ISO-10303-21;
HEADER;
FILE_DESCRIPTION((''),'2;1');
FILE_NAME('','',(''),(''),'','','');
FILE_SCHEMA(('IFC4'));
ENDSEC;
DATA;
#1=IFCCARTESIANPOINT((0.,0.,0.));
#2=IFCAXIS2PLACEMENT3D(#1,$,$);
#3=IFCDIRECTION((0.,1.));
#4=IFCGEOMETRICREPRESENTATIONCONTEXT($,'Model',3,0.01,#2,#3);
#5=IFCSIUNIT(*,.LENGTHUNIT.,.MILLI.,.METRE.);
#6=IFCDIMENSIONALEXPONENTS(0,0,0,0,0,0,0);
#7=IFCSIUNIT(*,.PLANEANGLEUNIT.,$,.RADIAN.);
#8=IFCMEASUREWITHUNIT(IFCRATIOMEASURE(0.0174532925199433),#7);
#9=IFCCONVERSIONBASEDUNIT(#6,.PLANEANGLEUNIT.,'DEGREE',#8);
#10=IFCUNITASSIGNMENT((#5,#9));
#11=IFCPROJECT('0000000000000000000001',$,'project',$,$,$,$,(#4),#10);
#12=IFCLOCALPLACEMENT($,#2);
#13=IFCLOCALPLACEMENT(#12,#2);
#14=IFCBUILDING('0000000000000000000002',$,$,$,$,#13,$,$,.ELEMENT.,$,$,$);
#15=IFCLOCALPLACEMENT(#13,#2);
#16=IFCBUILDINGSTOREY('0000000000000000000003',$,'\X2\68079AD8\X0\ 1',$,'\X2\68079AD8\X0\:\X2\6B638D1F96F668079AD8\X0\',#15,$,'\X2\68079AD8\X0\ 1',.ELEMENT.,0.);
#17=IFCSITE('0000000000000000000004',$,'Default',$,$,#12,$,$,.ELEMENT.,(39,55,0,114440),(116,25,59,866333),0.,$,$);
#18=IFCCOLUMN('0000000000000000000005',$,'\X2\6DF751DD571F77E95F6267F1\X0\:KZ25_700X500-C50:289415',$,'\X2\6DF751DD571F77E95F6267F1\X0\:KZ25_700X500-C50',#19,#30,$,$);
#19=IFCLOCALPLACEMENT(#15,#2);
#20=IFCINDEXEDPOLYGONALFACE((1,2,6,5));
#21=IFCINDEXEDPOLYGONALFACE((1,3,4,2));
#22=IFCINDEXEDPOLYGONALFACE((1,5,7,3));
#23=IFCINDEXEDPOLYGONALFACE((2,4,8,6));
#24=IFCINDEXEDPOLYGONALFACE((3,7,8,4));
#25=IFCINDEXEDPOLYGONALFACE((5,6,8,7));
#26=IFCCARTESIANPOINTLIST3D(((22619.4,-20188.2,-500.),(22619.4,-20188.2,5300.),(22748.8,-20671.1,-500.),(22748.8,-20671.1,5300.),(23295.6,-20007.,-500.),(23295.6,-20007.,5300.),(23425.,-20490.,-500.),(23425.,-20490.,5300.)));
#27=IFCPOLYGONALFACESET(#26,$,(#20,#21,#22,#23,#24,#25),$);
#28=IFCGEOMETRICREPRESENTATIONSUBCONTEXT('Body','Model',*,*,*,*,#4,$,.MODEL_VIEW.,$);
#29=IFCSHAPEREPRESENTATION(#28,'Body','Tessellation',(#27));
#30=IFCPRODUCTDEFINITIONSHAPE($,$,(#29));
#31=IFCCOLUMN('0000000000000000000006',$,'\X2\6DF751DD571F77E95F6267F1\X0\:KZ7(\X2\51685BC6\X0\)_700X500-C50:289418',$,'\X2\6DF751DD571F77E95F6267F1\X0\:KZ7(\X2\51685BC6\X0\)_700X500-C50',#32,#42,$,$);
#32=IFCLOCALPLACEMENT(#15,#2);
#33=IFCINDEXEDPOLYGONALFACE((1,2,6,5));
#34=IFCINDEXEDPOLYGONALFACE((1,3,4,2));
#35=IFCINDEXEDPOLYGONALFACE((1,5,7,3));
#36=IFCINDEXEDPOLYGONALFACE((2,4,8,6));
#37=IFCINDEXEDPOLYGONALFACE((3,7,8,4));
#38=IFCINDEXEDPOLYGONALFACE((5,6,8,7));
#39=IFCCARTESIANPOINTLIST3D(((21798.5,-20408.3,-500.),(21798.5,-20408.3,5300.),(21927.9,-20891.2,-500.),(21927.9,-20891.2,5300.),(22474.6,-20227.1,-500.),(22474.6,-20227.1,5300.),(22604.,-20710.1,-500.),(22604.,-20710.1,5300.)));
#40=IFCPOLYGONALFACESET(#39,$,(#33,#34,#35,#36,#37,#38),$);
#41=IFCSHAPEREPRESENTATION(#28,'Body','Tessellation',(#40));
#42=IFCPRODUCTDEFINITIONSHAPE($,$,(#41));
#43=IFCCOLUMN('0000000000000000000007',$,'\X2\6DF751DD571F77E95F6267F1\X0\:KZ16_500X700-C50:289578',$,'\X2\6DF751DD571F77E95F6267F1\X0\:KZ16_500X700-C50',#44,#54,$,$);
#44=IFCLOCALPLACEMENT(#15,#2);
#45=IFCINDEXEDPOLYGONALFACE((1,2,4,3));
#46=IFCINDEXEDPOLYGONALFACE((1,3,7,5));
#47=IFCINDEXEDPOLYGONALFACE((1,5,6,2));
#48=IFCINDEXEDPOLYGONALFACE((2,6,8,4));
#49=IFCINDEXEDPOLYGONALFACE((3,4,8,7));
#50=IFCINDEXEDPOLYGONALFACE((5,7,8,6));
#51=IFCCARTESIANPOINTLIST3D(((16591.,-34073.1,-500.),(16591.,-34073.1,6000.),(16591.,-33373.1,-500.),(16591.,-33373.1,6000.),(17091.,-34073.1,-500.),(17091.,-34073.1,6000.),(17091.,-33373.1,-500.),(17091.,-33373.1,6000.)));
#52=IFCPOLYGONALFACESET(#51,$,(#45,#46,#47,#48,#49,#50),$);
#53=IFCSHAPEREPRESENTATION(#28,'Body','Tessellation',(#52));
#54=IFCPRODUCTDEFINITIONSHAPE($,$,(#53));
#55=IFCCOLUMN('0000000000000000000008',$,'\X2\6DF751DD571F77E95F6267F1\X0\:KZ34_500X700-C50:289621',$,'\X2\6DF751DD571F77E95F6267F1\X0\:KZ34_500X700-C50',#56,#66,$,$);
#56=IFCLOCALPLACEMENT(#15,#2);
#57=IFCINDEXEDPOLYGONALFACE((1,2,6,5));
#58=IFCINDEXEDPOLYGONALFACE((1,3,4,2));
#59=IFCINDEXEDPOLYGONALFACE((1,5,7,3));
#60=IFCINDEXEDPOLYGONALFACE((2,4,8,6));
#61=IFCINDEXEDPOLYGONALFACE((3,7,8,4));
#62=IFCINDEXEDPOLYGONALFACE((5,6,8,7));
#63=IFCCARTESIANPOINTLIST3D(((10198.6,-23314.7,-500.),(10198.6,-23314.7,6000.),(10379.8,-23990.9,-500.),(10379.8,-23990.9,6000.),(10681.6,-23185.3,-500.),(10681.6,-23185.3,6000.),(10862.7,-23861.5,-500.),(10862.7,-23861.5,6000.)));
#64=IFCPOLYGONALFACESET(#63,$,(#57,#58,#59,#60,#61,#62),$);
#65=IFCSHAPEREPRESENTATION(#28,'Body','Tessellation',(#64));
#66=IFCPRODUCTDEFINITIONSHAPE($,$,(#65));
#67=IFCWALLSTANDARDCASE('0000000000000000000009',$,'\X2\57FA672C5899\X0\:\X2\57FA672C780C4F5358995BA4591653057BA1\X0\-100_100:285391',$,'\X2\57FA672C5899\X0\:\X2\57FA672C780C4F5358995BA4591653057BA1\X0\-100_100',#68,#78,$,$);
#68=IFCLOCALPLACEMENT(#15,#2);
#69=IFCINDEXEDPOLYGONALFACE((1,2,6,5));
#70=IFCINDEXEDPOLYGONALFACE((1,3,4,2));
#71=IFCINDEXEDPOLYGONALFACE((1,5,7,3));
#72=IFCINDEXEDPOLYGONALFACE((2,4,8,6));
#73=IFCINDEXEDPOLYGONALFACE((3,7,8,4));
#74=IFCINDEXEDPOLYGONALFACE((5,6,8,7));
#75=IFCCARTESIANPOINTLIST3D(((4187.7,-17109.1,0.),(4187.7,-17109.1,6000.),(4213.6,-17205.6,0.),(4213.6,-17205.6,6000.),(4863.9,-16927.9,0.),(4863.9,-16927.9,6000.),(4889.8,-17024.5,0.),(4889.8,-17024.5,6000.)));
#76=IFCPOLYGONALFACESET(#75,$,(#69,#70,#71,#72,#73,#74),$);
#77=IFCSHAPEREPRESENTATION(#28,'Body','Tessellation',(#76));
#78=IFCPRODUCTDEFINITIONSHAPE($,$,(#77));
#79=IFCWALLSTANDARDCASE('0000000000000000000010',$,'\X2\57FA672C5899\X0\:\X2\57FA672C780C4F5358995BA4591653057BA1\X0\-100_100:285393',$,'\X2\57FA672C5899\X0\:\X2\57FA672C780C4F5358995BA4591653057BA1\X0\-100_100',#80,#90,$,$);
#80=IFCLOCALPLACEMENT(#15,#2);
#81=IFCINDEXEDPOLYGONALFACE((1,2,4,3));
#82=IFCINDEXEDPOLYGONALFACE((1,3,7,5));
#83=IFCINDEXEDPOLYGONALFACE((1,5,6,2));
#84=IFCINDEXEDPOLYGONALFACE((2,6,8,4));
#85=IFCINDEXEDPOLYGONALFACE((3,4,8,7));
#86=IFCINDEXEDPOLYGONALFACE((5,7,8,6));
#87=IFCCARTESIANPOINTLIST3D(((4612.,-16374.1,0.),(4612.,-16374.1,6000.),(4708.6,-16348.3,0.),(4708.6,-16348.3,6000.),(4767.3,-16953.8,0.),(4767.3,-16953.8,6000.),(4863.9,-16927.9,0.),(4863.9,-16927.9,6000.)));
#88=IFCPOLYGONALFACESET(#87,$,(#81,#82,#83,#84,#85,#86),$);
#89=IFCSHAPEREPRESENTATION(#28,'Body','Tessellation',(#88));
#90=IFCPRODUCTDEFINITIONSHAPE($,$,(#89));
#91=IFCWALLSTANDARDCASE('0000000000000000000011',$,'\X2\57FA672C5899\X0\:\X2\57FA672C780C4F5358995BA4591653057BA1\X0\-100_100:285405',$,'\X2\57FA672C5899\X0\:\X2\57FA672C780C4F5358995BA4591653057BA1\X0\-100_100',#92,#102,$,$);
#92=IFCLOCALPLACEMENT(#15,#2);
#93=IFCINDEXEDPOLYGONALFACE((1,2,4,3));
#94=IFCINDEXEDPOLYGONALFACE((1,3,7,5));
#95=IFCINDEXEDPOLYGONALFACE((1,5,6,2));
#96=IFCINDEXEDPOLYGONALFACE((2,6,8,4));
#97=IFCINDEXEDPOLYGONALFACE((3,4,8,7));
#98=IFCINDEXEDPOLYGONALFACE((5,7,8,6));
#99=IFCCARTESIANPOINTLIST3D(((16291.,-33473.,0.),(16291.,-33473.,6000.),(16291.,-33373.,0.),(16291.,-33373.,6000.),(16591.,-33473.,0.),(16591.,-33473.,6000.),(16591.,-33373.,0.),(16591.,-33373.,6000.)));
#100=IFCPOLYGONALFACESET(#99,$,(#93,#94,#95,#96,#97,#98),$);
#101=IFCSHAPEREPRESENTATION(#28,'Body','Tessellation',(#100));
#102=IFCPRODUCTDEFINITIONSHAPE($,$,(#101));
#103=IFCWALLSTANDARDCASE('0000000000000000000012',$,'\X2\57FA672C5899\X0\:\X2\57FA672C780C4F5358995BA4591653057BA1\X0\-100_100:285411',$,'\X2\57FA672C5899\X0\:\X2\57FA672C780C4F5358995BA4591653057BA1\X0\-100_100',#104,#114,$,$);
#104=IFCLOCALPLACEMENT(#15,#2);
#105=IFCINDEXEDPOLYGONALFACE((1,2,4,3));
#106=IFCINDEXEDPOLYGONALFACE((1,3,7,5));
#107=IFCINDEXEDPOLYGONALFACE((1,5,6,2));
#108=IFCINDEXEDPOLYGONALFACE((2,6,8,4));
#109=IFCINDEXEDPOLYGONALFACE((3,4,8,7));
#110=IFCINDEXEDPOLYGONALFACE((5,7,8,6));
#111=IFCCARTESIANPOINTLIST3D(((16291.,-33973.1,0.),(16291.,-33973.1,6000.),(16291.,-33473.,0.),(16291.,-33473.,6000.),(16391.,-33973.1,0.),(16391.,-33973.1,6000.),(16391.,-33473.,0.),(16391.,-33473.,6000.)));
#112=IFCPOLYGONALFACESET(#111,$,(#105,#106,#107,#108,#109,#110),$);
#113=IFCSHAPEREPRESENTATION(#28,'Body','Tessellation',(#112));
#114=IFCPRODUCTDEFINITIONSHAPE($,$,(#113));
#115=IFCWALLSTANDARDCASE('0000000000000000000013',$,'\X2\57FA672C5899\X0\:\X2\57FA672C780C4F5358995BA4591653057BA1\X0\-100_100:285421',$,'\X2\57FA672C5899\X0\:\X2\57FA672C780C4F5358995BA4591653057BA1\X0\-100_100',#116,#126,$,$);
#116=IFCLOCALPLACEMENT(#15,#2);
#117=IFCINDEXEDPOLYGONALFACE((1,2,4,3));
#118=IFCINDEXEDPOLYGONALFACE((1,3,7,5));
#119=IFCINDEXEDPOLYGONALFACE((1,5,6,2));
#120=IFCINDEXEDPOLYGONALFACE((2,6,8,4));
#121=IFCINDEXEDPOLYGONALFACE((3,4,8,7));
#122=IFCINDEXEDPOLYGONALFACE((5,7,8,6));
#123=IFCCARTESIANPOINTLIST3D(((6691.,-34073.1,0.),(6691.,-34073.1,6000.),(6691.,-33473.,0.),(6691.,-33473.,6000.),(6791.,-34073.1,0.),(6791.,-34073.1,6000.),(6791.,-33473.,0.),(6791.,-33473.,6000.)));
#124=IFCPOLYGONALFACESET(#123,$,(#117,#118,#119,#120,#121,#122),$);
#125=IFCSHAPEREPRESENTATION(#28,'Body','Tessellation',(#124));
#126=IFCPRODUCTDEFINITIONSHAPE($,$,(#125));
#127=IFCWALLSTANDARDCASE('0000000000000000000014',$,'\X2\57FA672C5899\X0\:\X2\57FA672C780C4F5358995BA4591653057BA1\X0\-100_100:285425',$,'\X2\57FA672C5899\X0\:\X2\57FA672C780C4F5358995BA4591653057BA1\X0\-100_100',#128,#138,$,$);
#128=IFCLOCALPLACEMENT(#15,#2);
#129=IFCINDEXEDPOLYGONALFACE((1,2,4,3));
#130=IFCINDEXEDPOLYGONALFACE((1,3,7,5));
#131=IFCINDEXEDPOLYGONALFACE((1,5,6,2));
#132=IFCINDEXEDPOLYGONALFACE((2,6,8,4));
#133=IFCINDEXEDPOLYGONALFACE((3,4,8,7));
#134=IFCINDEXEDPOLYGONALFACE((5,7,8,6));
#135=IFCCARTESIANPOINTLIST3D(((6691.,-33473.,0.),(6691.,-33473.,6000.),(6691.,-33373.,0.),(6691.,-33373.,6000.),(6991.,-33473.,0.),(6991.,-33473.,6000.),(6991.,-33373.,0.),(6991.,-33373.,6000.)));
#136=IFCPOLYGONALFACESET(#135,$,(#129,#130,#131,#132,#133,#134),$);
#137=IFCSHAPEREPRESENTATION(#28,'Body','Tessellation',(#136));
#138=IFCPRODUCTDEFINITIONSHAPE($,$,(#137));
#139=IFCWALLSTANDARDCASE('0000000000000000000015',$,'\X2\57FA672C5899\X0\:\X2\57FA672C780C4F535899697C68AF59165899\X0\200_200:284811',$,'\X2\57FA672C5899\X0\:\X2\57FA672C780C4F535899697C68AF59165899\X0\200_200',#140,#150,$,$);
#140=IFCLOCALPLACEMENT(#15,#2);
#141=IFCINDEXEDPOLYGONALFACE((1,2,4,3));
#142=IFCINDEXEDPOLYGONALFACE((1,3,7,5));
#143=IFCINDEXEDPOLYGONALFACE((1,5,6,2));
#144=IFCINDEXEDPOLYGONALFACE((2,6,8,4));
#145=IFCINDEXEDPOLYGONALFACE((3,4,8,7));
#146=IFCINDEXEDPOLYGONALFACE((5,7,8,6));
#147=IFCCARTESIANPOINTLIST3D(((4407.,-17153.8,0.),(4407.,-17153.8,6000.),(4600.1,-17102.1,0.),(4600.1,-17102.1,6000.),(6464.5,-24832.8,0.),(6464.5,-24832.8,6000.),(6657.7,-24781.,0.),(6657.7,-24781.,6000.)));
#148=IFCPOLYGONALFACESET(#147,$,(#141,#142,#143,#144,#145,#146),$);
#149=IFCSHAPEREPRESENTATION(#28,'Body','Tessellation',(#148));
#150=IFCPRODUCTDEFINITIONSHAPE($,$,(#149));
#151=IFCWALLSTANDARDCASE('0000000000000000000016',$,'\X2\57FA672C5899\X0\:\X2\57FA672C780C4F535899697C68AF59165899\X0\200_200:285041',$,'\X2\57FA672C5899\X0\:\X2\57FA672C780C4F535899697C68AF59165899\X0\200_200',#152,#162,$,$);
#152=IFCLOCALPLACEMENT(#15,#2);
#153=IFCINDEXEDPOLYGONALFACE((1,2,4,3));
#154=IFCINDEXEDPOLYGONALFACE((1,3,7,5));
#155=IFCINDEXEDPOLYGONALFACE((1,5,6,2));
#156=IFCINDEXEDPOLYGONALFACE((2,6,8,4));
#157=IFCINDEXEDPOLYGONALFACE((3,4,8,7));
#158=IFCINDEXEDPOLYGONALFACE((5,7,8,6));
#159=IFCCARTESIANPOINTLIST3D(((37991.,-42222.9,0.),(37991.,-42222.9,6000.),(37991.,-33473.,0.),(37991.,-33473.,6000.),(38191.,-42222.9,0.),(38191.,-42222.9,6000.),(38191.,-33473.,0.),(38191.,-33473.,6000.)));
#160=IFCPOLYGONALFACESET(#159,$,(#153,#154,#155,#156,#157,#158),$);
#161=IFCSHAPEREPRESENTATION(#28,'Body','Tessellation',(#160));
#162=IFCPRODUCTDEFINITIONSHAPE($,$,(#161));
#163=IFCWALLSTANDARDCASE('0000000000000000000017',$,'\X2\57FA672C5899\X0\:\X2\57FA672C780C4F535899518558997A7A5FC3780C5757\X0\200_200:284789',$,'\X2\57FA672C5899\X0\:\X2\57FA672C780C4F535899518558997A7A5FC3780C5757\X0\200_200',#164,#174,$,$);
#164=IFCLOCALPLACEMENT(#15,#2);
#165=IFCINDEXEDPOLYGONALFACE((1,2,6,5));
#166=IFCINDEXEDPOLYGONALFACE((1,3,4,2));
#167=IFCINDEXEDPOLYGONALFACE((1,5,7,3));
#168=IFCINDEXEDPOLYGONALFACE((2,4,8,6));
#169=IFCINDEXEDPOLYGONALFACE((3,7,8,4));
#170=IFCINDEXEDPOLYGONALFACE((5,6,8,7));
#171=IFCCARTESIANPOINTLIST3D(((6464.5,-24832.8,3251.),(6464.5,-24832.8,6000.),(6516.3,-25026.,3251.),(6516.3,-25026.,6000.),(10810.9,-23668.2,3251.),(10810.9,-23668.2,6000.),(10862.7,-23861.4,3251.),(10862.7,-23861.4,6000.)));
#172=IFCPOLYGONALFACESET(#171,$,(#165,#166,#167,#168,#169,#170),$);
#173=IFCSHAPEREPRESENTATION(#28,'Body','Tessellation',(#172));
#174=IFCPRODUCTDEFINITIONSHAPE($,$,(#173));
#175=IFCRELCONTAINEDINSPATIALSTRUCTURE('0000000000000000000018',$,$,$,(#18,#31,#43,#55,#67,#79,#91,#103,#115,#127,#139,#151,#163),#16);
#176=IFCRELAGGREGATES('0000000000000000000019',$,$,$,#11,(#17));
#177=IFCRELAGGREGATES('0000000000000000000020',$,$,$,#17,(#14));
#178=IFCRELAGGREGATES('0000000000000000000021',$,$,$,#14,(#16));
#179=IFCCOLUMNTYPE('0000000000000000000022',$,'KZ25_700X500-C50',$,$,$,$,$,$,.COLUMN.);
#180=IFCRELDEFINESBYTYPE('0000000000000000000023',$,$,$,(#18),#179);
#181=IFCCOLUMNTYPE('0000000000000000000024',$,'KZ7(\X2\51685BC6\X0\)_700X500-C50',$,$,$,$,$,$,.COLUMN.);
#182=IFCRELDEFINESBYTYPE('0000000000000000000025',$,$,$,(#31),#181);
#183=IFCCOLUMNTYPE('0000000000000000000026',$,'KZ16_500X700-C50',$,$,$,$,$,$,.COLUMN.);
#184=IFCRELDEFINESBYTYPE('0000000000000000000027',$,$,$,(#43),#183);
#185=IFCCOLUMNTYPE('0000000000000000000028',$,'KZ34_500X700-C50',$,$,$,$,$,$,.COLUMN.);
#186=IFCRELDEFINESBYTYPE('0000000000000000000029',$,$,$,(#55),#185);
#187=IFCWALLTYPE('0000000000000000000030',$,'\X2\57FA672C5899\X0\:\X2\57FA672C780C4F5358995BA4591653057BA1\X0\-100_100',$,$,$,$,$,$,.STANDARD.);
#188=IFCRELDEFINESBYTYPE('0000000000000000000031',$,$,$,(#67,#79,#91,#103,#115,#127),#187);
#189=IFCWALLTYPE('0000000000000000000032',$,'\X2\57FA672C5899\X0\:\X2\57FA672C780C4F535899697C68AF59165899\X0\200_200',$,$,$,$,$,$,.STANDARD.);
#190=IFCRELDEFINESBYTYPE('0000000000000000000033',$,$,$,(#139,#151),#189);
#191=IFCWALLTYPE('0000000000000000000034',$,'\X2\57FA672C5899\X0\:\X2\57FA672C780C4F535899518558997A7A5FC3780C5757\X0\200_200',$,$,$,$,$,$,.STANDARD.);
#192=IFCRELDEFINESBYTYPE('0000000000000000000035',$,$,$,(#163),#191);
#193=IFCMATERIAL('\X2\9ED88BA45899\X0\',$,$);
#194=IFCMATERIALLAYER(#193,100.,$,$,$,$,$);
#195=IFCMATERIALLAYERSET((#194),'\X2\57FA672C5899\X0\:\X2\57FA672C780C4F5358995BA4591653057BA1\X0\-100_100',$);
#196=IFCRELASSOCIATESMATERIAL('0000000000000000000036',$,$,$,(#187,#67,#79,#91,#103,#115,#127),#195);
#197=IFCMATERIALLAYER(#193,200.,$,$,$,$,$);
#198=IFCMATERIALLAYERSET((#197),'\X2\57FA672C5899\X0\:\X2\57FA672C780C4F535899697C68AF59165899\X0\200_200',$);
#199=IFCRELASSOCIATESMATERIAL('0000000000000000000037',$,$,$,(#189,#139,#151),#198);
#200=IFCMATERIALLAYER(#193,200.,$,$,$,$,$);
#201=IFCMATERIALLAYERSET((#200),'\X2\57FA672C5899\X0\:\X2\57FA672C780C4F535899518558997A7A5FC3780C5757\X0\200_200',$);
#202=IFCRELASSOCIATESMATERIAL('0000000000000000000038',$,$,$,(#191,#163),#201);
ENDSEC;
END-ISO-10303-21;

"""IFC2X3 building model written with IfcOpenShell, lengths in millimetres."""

from ifc_helpers import new_model, entity, si_unit, converted_unit, direction, frame, frame_2d, origin, origin_2d_with_axis, place, context, subcontext, project, spatial, rectangle, extrude, source, transform, mapped, material, layer, layer_set, layer_usage, type_object, type_shapes, element, save


model = new_model("IFC2X3")

# Units and contexts
model_context = context("Model", 3, precision=0.01, world=origin(), true_north=direction((0.0, 1.0)))
body_context = subcontext(model_context, "Body", "Model", "MODEL_VIEW")
ifc_project = project(units=[si_unit("LENGTHUNIT", "METRE", prefix="MILLI"), converted_unit("PLANEANGLEUNIT", "DEGREE", entity("IfcRatioMeasure", 0.0174532925199433), si_unit("PLANEANGLEUNIT", "RADIAN"), dimensions=[0, 0, 0, 0, 0, 0, 0])], contexts=[model_context])

# Site, building, storey
site_placement = place(None, origin())
site = spatial("IfcSite", under=ifc_project, at=site_placement, Name="Default", CompositionType="ELEMENT", RefLatitude=(39, 55, 0, 114440), RefLongitude=(116, 25, 59, 866333), RefElevation=0.0)
building_placement = place(site_placement, origin())
building = spatial("IfcBuilding", under=site, at=building_placement, CompositionType="ELEMENT")
storey_placement = place(building_placement, origin())
storey = spatial("IfcBuildingStorey", under=building, at=storey_placement, Name="标高 1", ObjectType="标高:正负零标高", LongName="标高 1", CompositionType="ELEMENT", Elevation=0.0)

# Columns
column_type_1 = type_object("IfcColumnType", Name="KZ25_700X500-C50", PredefinedType="COLUMN")
shared_shape_1 = source(origin(), body_context, "Body", "SweptSolid", [
    extrude(rectangle(XDim=500.0, YDim=700.0, at=origin_2d_with_axis()), frame((0.0, 0.0, -500.0), z_axis=(0.0, 0.0, 1.0), x_axis=(0.0, -1.0, 0.0)), (0.0, 0.0, 1.0), 5800.0),
])
type_shapes(column_type_1, [shared_shape_1])
column_1_placement = place(building_placement, frame((23022.2, -20339.1, 0.0), z_axis=(0.0, 0.0, 1.0), x_axis=(0.965926, 0.258819, 0.0)))
element("IfcColumn", 1, at=column_1_placement, inside=storey, type_object=column_type_1, Name="混凝土矩形柱:KZ25_700X500-C50:289415", ObjectType="混凝土矩形柱:KZ25_700X500-C50", context=body_context, shape_type="MappedRepresentation", body=[
    mapped(shared_shape_1, transform((0.0, 0.0, 0.0), scale=1.0)),
])
column_type_2 = type_object("IfcColumnType", Name="KZ7(全密)_700X500-C50", PredefinedType="COLUMN")
shared_shape_2 = source(origin(), body_context, "Body", "SweptSolid", [
    extrude(rectangle(XDim=500.0, YDim=700.0, at=origin_2d_with_axis()), frame((0.0, 0.0, -500.0), z_axis=(0.0, 0.0, 1.0), x_axis=(0.0, -1.0, 0.0)), (0.0, 0.0, 1.0), 5800.0),
])
type_shapes(column_type_2, [shared_shape_2])
column_2_placement = place(building_placement, frame((22201.2, -20559.2, 0.0), z_axis=(0.0, 0.0, 1.0), x_axis=(0.965926, 0.258819, 0.0)))
element("IfcColumn", 2, at=column_2_placement, inside=storey, type_object=column_type_2, Name="混凝土矩形柱:KZ7(全密)_700X500-C50:289418", ObjectType="混凝土矩形柱:KZ7(全密)_700X500-C50", context=body_context, shape_type="MappedRepresentation", body=[
    mapped(shared_shape_2, transform((0.0, 0.0, 0.0), scale=1.0)),
])
column_type_3 = type_object("IfcColumnType", Name="KZ16_500X700-C50", PredefinedType="COLUMN")
shared_shape_3 = source(origin(), body_context, "Body", "SweptSolid", [
    extrude(rectangle(XDim=700.0, YDim=500.0, at=origin_2d_with_axis()), frame((0.0, 0.0, -500.0), z_axis=(0.0, 0.0, 1.0), x_axis=(0.0, -1.0, 0.0)), (0.0, 0.0, 1.0), 6500.0),
])
type_shapes(column_type_3, [shared_shape_3])
column_3_placement = place(building_placement, frame((16841.0, -33723.1, 0.0)))
element("IfcColumn", 3, at=column_3_placement, inside=storey, type_object=column_type_3, Name="混凝土矩形柱:KZ16_500X700-C50:289578", ObjectType="混凝土矩形柱:KZ16_500X700-C50", context=body_context, shape_type="MappedRepresentation", body=[
    mapped(shared_shape_3, transform((0.0, 0.0, 0.0), scale=1.0)),
])
column_type_4 = type_object("IfcColumnType", Name="KZ34_500X700-C50", PredefinedType="COLUMN")
shared_shape_4 = source(origin(), body_context, "Body", "SweptSolid", [
    extrude(rectangle(XDim=700.0, YDim=500.0, at=origin_2d_with_axis()), frame((0.0, 0.0, -500.0), z_axis=(0.0, 0.0, 1.0), x_axis=(0.0, -1.0, 0.0)), (0.0, 0.0, 1.0), 6500.0),
])
type_shapes(column_type_4, [shared_shape_4])
column_4_placement = place(building_placement, frame((10530.7, -23588.1, 0.0), z_axis=(0.0, 0.0, 1.0), x_axis=(0.965926, 0.258819, 0.0)))
element("IfcColumn", 4, at=column_4_placement, inside=storey, type_object=column_type_4, Name="混凝土矩形柱:KZ34_500X700-C50:289621", ObjectType="混凝土矩形柱:KZ34_500X700-C50", context=body_context, shape_type="MappedRepresentation", body=[
    mapped(shared_shape_4, transform((0.0, 0.0, 0.0), scale=1.0)),
])

# Walls
ifc_material = material(Name="默认墙")
ifc_layer_1 = layer(ifc_material, 100.0)
ifc_layer_set_1 = layer_set([ifc_layer_1], Name="基本墙:基本砌体墙室外包管-100_100")
ifc_layer_usage_1 = layer_usage(ifc_layer_set_1, "AXIS2", "NEGATIVE", 50.0)
wall_type_1 = type_object("IfcWallType", Name="基本墙:基本砌体墙室外包管-100_100", PredefinedType="STANDARD", material=ifc_layer_set_1)
wall_1_placement = place(building_placement, frame((4200.7, -17157.3, 0.0), z_axis=(0.0, 0.0, 1.0), x_axis=(0.965926, 0.258819, 0.0)))
element("IfcWallStandardCase", 5, at=wall_1_placement, inside=storey, type_object=wall_type_1, material=ifc_layer_usage_1, Name="基本墙:基本砌体墙室外包管-100_100:285391", ObjectType="基本墙:基本砌体墙室外包管-100_100", context=body_context, shape_type="SweptSolid", body=[
    extrude(rectangle(XDim=700.0, YDim=100.0, at=frame_2d((350.0, 0.0), x_axis=(-1.0, 0.0))), origin(), (0.0, 0.0, 1.0), 6000.0),
])
ifc_layer_usage_2 = layer_usage(ifc_layer_set_1, "AXIS2", "NEGATIVE", 50.0)
wall_2_placement = place(building_placement, frame((4815.6, -16940.8, 0.0), z_axis=(0.0, 0.0, 1.0), x_axis=(-0.258819, 0.965926, 0.0)))
element("IfcWallStandardCase", 6, at=wall_2_placement, inside=storey, type_object=wall_type_1, material=ifc_layer_usage_2, Name="基本墙:基本砌体墙室外包管-100_100:285393", ObjectType="基本墙:基本砌体墙室外包管-100_100", context=body_context, shape_type="SweptSolid", body=[
    extrude(rectangle(XDim=600.1, YDim=100.0, at=frame_2d((300.0, 0.0), x_axis=(-1.0, 0.0))), origin(), (0.0, 0.0, 1.0), 6000.0),
])
ifc_layer_usage_3 = layer_usage(ifc_layer_set_1, "AXIS2", "NEGATIVE", 50.0)
wall_3_placement = place(building_placement, frame((16291.0, -33423.0, 0.0)))
element("IfcWallStandardCase", 7, at=wall_3_placement, inside=storey, type_object=wall_type_1, material=ifc_layer_usage_3, Name="基本墙:基本砌体墙室外包管-100_100:285405", ObjectType="基本墙:基本砌体墙室外包管-100_100", context=body_context, shape_type="SweptSolid", body=[
    extrude(rectangle(XDim=300.0, YDim=100.0, at=frame_2d((150.0, 0.0), x_axis=(-1.0, 0.0))), origin(), (0.0, 0.0, 1.0), 6000.0),
])
ifc_layer_usage_4 = layer_usage(ifc_layer_set_1, "AXIS2", "NEGATIVE", 50.0)
wall_4_placement = place(building_placement, frame((16341.0, -33473.0, 0.0), z_axis=(0.0, 0.0, 1.0), x_axis=(0.0, -1.0, 0.0)))
element("IfcWallStandardCase", 8, at=wall_4_placement, inside=storey, type_object=wall_type_1, material=ifc_layer_usage_4, Name="基本墙:基本砌体墙室外包管-100_100:285411", ObjectType="基本墙:基本砌体墙室外包管-100_100", context=body_context, shape_type="SweptSolid", body=[
    extrude(rectangle(XDim=500.1, YDim=100.0, at=frame_2d((250.0, 0.0), x_axis=(-1.0, 0.0))), origin(), (0.0, 0.0, 1.0), 6000.0),
])
ifc_layer_usage_5 = layer_usage(ifc_layer_set_1, "AXIS2", "NEGATIVE", 50.0)
wall_5_placement = place(building_placement, frame((6741.0, -33473.0, 0.0), z_axis=(0.0, 0.0, 1.0), x_axis=(0.0, -1.0, 0.0)))
element("IfcWallStandardCase", 9, at=wall_5_placement, inside=storey, type_object=wall_type_1, material=ifc_layer_usage_5, Name="基本墙:基本砌体墙室外包管-100_100:285421", ObjectType="基本墙:基本砌体墙室外包管-100_100", context=body_context, shape_type="SweptSolid", body=[
    extrude(rectangle(XDim=600.1, YDim=100.0, at=frame_2d((300.0, 0.0), x_axis=(-1.0, 0.0))), origin(), (0.0, 0.0, 1.0), 6000.0),
])
ifc_layer_usage_6 = layer_usage(ifc_layer_set_1, "AXIS2", "NEGATIVE", 50.0)
wall_6_placement = place(building_placement, frame((6691.0, -33423.0, 0.0)))
element("IfcWallStandardCase", 10, at=wall_6_placement, inside=storey, type_object=wall_type_1, material=ifc_layer_usage_6, Name="基本墙:基本砌体墙室外包管-100_100:285425", ObjectType="基本墙:基本砌体墙室外包管-100_100", context=body_context, shape_type="SweptSolid", body=[
    extrude(rectangle(XDim=300.0, YDim=100.0, at=frame_2d((150.0, 0.0), x_axis=(-1.0, 0.0))), origin(), (0.0, 0.0, 1.0), 6000.0),
])
ifc_layer_2 = layer(ifc_material, 200.0)
ifc_layer_set_2 = layer_set([ifc_layer_2], Name="基本墙:基本砌体墙楼梯外墙200_200")
ifc_layer_usage_7 = layer_usage(ifc_layer_set_2, "AXIS2", "NEGATIVE", 100.0)
wall_type_2 = type_object("IfcWallType", Name="基本墙:基本砌体墙楼梯外墙200_200", PredefinedType="STANDARD", material=ifc_layer_set_2)
wall_7_placement = place(building_placement, frame((4503.6, -17128.0, 0.0), z_axis=(0.0, 0.0, 1.0), x_axis=(0.258819, -0.965926, 0.0)))
element("IfcWallStandardCase", 11, at=wall_7_placement, inside=storey, type_object=wall_type_2, material=ifc_layer_usage_7, Name="基本墙:基本砌体墙楼梯外墙200_200:284811", ObjectType="基本墙:基本砌体墙楼梯外墙200_200", context=body_context, shape_type="SweptSolid", body=[
    extrude(rectangle(XDim=7949.8, YDim=200.0, at=frame_2d((3974.9, 0.0), x_axis=(-1.0, 0.0))), origin(), (0.0, 0.0, 1.0), 6000.0),
])
ifc_layer_usage_8 = layer_usage(ifc_layer_set_2, "AXIS2", "NEGATIVE", 100.0)
wall_8_placement = place(building_placement, frame((38091.0, -33473.0, 0.0), z_axis=(0.0, 0.0, 1.0), x_axis=(0.0, -1.0, 0.0)))
element("IfcWallStandardCase", 12, at=wall_8_placement, inside=storey, type_object=wall_type_2, material=ifc_layer_usage_8, Name="基本墙:基本砌体墙楼梯外墙200_200:285041", ObjectType="基本墙:基本砌体墙楼梯外墙200_200", context=body_context, shape_type="SweptSolid", body=[
    extrude(rectangle(XDim=8749.9, YDim=200.0, at=frame_2d((4374.9, 0.0), x_axis=(-1.0, 0.0))), origin(), (0.0, 0.0, 1.0), 6000.0),
])
ifc_layer_3 = layer(ifc_material, 200.0)
ifc_layer_set_3 = layer_set([ifc_layer_3], Name="基本墙:基本砌体墙内墙空心砌块200_200")
ifc_layer_usage_9 = layer_usage(ifc_layer_set_3, "AXIS2", "NEGATIVE", 100.0)
wall_type_3 = type_object("IfcWallType", Name="基本墙:基本砌体墙内墙空心砌块200_200", PredefinedType="STANDARD", material=ifc_layer_set_3)
wall_9_placement = place(building_placement, frame((6490.4, -24929.4, 3251.0), z_axis=(0.0, 0.0, 1.0), x_axis=(0.965926, 0.258819, 0.0)))
element("IfcWallStandardCase", 13, at=wall_9_placement, inside=storey, type_object=wall_type_3, material=ifc_layer_usage_9, Name="基本墙:基本砌体墙内墙空心砌块200_200:284789", ObjectType="基本墙:基本砌体墙内墙空心砌块200_200", context=body_context, shape_type="SweptSolid", body=[
    extrude(rectangle(XDim=4499.7, YDim=200.0, at=frame_2d((2249.9, 0.0), x_axis=(-1.0, 0.0))), origin(), (0.0, 0.0, 1.0), 2749.0),
])

save(model, "model.ifc")
